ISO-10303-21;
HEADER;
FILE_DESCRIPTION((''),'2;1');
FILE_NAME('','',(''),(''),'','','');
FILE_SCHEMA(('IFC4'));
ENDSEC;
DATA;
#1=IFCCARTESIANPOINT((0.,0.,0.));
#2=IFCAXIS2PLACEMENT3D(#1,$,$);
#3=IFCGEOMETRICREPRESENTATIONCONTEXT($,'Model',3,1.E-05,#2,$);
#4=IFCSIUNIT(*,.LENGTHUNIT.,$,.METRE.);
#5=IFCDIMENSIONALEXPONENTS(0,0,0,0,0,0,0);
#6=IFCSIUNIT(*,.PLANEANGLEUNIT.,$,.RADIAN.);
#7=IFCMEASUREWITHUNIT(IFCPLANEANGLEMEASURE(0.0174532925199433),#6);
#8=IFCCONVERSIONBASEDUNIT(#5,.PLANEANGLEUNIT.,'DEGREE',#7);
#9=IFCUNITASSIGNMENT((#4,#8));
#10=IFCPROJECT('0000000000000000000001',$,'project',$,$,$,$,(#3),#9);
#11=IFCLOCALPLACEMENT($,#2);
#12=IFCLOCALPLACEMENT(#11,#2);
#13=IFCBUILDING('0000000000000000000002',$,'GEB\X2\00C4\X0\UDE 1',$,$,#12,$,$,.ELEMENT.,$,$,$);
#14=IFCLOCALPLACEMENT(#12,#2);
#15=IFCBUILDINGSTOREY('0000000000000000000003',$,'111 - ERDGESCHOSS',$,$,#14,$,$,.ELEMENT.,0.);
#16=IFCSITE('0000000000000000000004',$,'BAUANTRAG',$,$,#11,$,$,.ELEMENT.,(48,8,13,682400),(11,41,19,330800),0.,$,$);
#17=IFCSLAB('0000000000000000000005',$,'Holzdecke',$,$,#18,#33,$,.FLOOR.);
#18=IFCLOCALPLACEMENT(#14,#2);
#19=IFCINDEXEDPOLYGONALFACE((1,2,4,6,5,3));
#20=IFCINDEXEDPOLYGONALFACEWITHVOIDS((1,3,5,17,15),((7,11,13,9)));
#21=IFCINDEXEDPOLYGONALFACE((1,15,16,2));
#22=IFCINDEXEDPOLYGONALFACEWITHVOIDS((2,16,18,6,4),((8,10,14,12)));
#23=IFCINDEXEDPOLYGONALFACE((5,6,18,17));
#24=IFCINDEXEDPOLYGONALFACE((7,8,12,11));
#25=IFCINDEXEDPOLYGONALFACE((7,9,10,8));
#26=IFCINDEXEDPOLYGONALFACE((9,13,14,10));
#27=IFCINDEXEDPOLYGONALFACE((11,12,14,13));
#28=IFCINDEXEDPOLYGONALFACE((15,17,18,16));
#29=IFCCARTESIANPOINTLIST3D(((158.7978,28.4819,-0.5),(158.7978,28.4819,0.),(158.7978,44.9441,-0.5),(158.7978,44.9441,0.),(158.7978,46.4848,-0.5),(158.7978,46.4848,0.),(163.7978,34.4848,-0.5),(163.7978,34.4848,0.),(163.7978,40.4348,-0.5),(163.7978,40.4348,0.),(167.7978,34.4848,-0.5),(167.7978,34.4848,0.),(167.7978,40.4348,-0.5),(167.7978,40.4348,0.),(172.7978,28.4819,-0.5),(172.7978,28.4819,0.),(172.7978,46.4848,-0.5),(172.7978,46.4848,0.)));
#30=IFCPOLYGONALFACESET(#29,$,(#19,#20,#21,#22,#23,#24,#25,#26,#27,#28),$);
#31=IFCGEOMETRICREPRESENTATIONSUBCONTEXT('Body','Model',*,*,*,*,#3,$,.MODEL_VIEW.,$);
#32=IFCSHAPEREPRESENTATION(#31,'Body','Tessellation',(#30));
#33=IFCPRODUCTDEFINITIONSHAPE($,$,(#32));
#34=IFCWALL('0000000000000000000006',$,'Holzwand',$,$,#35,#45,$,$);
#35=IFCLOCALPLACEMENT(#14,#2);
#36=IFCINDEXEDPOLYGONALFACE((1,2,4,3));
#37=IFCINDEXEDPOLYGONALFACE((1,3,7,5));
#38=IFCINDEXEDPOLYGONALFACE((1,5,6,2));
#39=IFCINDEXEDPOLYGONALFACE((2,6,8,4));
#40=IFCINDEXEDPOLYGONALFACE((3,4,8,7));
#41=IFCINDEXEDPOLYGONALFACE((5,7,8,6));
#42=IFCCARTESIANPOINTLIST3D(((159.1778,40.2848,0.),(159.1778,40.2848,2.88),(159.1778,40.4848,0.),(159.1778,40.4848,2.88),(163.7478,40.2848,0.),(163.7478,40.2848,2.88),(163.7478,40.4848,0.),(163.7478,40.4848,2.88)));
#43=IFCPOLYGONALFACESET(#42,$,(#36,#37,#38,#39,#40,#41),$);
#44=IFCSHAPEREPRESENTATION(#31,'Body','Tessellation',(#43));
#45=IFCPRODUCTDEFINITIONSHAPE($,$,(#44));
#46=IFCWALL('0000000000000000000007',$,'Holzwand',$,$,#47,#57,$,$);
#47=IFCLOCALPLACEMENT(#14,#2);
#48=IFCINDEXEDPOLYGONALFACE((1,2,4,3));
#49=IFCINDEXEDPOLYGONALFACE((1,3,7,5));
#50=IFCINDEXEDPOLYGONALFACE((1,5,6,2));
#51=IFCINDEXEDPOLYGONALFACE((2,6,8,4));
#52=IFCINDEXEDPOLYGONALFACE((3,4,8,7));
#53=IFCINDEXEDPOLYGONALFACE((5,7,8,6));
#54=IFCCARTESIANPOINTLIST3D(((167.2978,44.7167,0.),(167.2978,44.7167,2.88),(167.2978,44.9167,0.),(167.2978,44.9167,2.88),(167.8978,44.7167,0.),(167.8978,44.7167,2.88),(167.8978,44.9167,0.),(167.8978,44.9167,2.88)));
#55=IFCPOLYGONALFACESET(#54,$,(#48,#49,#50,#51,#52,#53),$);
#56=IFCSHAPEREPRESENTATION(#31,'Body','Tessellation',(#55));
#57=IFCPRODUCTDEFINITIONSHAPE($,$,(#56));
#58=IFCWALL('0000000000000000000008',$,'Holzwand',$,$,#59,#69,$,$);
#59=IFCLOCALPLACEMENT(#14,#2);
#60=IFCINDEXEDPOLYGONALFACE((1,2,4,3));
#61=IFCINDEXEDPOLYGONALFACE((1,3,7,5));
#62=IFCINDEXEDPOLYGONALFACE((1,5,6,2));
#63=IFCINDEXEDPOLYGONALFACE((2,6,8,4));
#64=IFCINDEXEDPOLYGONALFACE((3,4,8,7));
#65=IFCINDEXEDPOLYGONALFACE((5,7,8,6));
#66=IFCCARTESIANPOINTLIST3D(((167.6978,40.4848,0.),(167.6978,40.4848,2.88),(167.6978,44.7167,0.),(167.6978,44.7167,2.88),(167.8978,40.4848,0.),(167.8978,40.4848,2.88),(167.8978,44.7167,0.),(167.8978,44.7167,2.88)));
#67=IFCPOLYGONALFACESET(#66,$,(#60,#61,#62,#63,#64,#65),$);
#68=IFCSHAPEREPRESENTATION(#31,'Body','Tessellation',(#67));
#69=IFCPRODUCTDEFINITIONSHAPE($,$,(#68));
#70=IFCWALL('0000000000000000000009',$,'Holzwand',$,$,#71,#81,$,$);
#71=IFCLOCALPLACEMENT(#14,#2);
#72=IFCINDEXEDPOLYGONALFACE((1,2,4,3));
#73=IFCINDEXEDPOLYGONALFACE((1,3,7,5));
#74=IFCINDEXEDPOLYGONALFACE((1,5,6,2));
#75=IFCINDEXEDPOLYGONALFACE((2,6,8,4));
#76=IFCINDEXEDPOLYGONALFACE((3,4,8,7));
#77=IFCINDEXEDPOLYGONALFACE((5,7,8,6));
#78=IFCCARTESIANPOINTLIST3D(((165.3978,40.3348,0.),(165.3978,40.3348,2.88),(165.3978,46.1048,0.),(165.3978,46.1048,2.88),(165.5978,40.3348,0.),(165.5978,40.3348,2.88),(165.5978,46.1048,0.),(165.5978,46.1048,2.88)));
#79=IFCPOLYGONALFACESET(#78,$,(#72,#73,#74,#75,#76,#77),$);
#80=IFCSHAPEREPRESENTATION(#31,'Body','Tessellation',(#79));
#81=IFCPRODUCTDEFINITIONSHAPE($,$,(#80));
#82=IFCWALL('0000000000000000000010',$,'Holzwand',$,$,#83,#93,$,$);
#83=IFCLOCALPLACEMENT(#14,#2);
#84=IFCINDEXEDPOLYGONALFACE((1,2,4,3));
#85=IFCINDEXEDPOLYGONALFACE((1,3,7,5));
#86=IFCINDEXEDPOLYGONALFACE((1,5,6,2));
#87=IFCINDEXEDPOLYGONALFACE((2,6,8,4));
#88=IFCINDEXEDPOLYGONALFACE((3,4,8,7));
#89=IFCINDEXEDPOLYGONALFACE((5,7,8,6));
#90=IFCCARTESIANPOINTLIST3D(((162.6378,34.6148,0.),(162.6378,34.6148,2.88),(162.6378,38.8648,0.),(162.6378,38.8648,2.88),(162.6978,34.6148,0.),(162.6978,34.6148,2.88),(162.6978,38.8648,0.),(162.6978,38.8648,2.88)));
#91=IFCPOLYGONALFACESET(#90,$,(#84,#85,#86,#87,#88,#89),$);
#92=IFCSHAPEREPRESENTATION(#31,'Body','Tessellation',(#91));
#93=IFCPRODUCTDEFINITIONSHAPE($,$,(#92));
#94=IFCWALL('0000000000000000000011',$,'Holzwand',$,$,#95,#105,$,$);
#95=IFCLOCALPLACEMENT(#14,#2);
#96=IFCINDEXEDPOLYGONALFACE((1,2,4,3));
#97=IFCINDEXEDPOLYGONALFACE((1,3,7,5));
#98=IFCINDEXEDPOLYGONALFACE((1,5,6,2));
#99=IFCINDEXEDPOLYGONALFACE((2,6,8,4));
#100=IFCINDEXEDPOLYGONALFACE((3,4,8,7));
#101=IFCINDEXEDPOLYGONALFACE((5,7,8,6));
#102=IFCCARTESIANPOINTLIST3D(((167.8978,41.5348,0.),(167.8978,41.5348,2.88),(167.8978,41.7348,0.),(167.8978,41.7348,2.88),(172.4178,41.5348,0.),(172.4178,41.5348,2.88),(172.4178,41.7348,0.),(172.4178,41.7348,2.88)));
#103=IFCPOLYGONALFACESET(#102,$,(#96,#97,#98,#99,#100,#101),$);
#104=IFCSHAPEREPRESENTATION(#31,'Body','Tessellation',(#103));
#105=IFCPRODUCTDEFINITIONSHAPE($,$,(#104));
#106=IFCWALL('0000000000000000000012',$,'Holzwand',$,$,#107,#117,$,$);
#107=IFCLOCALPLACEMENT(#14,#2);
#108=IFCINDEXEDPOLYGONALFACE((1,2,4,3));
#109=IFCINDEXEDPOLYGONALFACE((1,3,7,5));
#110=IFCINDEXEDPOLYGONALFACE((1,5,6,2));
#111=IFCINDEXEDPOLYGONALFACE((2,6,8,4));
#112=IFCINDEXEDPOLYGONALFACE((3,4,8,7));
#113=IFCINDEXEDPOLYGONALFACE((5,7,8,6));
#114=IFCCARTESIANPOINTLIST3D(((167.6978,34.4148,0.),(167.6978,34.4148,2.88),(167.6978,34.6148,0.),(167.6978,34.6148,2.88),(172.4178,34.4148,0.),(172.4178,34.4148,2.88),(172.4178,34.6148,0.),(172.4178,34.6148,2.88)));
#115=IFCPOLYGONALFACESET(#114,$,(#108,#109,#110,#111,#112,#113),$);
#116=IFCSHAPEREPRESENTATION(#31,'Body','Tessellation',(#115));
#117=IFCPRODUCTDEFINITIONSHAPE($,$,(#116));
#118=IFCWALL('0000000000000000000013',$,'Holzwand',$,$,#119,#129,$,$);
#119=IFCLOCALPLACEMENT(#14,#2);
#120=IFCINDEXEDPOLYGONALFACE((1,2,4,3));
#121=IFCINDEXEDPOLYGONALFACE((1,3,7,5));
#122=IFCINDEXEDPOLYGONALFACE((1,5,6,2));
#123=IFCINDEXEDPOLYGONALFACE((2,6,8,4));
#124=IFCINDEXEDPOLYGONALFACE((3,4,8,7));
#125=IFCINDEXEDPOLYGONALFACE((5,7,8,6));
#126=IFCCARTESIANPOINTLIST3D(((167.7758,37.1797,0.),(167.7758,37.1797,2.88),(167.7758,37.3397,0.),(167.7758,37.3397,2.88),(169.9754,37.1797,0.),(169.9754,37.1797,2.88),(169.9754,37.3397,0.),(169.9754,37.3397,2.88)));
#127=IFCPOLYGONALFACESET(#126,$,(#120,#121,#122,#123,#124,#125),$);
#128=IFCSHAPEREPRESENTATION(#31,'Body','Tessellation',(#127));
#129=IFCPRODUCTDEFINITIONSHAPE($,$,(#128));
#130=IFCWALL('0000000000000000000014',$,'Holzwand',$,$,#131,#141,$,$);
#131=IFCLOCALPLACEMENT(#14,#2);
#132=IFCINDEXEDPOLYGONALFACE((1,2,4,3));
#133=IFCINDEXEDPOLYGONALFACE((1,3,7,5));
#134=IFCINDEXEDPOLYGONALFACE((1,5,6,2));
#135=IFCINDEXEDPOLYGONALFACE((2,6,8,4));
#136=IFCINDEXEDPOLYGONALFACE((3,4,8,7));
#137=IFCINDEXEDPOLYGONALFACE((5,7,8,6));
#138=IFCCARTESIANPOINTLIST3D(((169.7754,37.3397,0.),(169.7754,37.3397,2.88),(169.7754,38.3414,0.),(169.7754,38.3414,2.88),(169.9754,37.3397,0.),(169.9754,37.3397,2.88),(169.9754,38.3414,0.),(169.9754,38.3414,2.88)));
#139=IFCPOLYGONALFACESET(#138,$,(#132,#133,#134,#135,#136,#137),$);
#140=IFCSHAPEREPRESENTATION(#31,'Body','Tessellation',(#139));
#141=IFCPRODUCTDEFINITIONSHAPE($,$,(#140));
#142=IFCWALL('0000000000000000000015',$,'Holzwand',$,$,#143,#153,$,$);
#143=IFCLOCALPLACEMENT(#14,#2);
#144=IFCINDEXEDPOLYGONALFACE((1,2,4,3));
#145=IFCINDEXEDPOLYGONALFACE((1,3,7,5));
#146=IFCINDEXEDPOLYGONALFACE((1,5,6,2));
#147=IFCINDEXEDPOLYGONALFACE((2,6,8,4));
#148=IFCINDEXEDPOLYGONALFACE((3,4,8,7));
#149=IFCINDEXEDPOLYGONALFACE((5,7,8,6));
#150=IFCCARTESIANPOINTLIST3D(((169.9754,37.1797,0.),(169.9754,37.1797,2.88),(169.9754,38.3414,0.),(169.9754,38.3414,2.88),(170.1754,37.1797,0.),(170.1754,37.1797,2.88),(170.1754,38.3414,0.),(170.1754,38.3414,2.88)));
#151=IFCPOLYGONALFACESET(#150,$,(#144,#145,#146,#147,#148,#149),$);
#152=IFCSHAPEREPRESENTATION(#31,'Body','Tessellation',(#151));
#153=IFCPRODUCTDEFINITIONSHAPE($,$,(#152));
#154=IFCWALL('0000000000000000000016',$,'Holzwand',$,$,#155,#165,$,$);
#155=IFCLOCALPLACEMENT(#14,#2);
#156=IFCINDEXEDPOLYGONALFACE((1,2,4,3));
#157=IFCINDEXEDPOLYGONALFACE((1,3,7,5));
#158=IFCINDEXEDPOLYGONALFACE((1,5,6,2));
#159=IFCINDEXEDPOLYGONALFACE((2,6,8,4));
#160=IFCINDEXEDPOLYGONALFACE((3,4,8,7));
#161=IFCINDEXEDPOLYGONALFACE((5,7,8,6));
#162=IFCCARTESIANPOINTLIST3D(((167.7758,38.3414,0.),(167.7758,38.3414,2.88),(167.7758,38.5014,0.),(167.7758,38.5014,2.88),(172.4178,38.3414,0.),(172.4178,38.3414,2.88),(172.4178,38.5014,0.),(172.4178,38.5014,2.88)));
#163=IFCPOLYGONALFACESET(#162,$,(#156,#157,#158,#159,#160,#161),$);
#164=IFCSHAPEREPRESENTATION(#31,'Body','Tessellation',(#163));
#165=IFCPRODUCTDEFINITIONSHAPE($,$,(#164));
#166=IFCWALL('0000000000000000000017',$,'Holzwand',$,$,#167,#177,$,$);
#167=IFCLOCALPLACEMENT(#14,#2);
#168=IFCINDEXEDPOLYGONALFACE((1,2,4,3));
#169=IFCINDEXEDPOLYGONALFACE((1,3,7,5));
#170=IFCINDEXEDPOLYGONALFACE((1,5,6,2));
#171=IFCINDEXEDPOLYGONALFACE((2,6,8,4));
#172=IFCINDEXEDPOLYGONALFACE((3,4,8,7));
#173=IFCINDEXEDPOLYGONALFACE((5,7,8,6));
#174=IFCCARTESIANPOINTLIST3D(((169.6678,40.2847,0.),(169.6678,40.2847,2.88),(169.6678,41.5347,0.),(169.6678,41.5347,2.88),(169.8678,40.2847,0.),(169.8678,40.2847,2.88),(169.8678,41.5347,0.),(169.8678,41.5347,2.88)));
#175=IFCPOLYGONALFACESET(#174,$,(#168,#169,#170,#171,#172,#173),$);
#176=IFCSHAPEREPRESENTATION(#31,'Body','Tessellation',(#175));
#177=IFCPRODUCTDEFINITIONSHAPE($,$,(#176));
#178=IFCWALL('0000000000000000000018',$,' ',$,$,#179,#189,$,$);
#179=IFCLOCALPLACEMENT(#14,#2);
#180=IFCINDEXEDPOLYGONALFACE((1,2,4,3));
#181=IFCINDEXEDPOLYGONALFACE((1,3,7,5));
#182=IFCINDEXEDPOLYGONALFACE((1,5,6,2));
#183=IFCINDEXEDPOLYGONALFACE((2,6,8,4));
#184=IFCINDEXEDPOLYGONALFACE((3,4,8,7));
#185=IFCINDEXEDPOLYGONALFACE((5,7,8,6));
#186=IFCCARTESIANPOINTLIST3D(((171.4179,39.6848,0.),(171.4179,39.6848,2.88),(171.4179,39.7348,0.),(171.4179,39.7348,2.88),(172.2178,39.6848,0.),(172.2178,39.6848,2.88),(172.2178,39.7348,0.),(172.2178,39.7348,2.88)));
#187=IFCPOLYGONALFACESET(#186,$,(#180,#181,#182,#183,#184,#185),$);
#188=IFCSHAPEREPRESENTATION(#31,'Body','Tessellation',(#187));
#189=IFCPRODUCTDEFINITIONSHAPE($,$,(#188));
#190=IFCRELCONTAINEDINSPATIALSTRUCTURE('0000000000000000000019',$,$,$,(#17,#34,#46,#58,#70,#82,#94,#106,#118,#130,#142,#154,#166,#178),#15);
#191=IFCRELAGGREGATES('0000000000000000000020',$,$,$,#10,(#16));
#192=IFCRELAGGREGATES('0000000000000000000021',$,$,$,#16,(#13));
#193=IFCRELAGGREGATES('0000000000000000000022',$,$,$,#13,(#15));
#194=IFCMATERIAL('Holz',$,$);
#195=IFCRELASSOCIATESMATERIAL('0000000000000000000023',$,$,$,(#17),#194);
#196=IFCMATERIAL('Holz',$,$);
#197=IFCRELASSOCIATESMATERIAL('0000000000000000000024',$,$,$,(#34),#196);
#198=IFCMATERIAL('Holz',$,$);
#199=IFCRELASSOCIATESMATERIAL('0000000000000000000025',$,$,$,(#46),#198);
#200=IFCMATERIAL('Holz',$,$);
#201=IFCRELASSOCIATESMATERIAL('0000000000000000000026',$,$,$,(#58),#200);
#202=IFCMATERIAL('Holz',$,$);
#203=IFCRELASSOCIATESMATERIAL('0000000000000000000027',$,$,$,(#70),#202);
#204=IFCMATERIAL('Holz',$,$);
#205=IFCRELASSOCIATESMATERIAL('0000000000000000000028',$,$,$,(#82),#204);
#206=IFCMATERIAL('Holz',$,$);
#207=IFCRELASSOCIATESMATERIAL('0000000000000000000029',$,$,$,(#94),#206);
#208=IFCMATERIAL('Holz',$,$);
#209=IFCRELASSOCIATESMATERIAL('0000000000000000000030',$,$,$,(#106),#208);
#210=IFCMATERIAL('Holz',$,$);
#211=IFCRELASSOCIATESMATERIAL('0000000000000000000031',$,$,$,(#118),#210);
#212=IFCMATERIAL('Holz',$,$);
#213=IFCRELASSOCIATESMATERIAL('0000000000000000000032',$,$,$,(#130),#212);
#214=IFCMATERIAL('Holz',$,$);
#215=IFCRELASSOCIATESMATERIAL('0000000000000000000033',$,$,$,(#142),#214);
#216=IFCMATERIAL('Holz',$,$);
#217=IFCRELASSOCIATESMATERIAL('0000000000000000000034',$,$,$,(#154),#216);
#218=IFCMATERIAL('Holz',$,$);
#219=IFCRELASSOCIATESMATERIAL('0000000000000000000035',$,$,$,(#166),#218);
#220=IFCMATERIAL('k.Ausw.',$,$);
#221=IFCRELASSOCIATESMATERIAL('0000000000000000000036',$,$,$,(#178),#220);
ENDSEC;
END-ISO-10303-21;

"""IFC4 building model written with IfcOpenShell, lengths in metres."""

from ifc_helpers import new_model, entity, si_unit, converted_unit, frame, origin, origin_with_axes, place, context, subcontext, project, spatial, indexed_curve, outline, extrude, material, element, save


model = new_model("IFC4")

# Units and contexts
model_context = context("Model", 3, precision=1e-05, world=origin())
body_context = subcontext(model_context, "Body", "Model", "MODEL_VIEW")
ifc_project = project(units=[si_unit("LENGTHUNIT", "METRE"), converted_unit("PLANEANGLEUNIT", "DEGREE", entity("IfcPlaneAngleMeasure", 0.0174532925199433), si_unit("PLANEANGLEUNIT", "RADIAN"), dimensions=[0, 0, 0, 0, 0, 0, 0])], contexts=[model_context])

# Site, building, storey
site_placement = place(None, origin())
site = spatial("IfcSite", under=ifc_project, at=site_placement, Name="BAUANTRAG", CompositionType="ELEMENT", RefLatitude=(48, 8, 13, 682400), RefLongitude=(11, 41, 19, 330800), RefElevation=0.0)
building_placement = place(site_placement, origin())
building = spatial("IfcBuilding", under=site, at=building_placement, Name="GEBÄUDE 1", CompositionType="ELEMENT")
storey_placement = place(building_placement, origin())
storey = spatial("IfcBuildingStorey", under=building, at=storey_placement, Name="111 - ERDGESCHOSS", CompositionType="ELEMENT", Elevation=0.0)

# Slab
ifc_material_1 = material(Name="Holz")
slab_placement = place(storey_placement, frame((158.7978, 28.4819, -0.5)))
element("IfcSlab", 1, at=slab_placement, inside=storey, material=ifc_material_1, Name="Holzdecke", PredefinedType="FLOOR", context=body_context, shape_type="SweptSolid", body=[
    extrude(outline(indexed_curve([(0.0, 16.4622), (0.0, 0.0), (14.0, 0.0), (14.0, 18.0029), (0.0, 18.0029), (0.0, 16.4622)], self_intersect=False), holes=[indexed_curve([(5.0, 11.9529), (9.0, 11.9529), (9.0, 6.0029), (5.0, 6.0029), (5.0, 11.9529)], self_intersect=False)]), origin_with_axes(), (0.0, 0.0, 1.0), 0.5),
])

# Walls
ifc_material_2 = material(Name="Holz")
wall_1_placement = place(storey_placement, frame((163.7478, 40.4848, 0.0), z_axis=(0.0, 0.0, 1.0), x_axis=(-1.0, 0.0, 0.0)))
element("IfcWall", 2, at=wall_1_placement, inside=storey, material=ifc_material_2, Name="Holzwand", context=body_context, shape_type="SweptSolid", body=[
    extrude(outline(indexed_curve([(-4.57, -0.2), (0.0, -0.2), (0.0, 0.0), (-4.57, 0.0), (-4.57, -0.2)], self_intersect=False)), frame((4.57, 0.2, 0.0), z_axis=(0.0, 0.0, 1.0), x_axis=(1.0, 0.0, 0.0)), (0.0, 0.0, 1.0), 2.88),
])
ifc_material_3 = material(Name="Holz")
wall_2_placement = place(storey_placement, frame((167.2978, 44.7167, 0.0)))
element("IfcWall", 3, at=wall_2_placement, inside=storey, material=ifc_material_3, Name="Holzwand", context=body_context, shape_type="SweptSolid", body=[
    extrude(outline(indexed_curve([(0.0, 0.0), (0.6, 0.0), (0.6, 0.2), (0.0, 0.2), (0.0, 0.0)], self_intersect=False)), origin_with_axes(), (0.0, 0.0, 1.0), 2.88),
])
ifc_material_4 = material(Name="Holz")
wall_3_placement = place(storey_placement, frame((167.6978, 44.7167, 0.0), z_axis=(0.0, 0.0, 1.0), x_axis=(0.0, -1.0, 0.0)))
element("IfcWall", 4, at=wall_3_placement, inside=storey, material=ifc_material_4, Name="Holzwand", context=body_context, shape_type="SweptSolid", body=[
    extrude(outline(indexed_curve([(-4.2319, 0.0), (0.0, 0.0), (0.0, 0.2), (-4.2319, 0.2), (-4.2319, 0.0)], self_intersect=False)), frame((4.2319, 0.0, 0.0), z_axis=(0.0, 0.0, 1.0), x_axis=(1.0, 0.0, 0.0)), (0.0, 0.0, 1.0), 2.88),
])
ifc_material_5 = material(Name="Holz")
wall_4_placement = place(storey_placement, frame((165.3978, 46.1048, 0.0), z_axis=(0.0, 0.0, 1.0), x_axis=(0.0, -1.0, 0.0)))
element("IfcWall", 5, at=wall_4_placement, inside=storey, material=ifc_material_5, Name="Holzwand", context=body_context, shape_type="SweptSolid", body=[
    extrude(outline(indexed_curve([(-5.77, 0.0), (0.0, 0.0), (0.0, 0.2), (-5.77, 0.2), (-5.77, 0.0)], self_intersect=False)), frame((5.77, 0.0, 0.0), z_axis=(0.0, 0.0, 1.0), x_axis=(1.0, 0.0, 0.0)), (0.0, 0.0, 1.0), 2.88),
])
ifc_material_6 = material(Name="Holz")
wall_5_placement = place(storey_placement, frame((162.6978, 34.6148, 0.0), z_axis=(0.0, 0.0, 1.0), x_axis=(0.0, 1.0, 0.0)))
element("IfcWall", 6, at=wall_5_placement, inside=storey, material=ifc_material_6, Name="Holzwand", context=body_context, shape_type="SweptSolid", body=[
    extrude(outline(indexed_curve([(0.0, -0.06), (4.25, -0.06), (4.25, 0.0), (0.0, 0.0), (0.0, -0.06)], self_intersect=False)), frame((0.0, 0.06, 0.0), z_axis=(0.0, 0.0, 1.0), x_axis=(1.0, 0.0, 0.0)), (0.0, 0.0, 1.0), 2.88),
])
ifc_material_7 = material(Name="Holz")
wall_6_placement = place(storey_placement, frame((172.4178, 41.7348, 0.0), z_axis=(0.0, 0.0, 1.0), x_axis=(-1.0, 0.0, 0.0)))
element("IfcWall", 7, at=wall_6_placement, inside=storey, material=ifc_material_7, Name="Holzwand", context=body_context, shape_type="SweptSolid", body=[
    extrude(outline(indexed_curve([(-4.52, -0.2), (0.0, -0.2), (0.0, 0.0), (-4.52, 0.0), (-4.52, -0.2)], self_intersect=False)), frame((4.52, 0.2, 0.0), z_axis=(0.0, 0.0, 1.0), x_axis=(1.0, 0.0, 0.0)), (0.0, 0.0, 1.0), 2.88),
])
ifc_material_8 = material(Name="Holz")
wall_7_placement = place(storey_placement, frame((167.6978, 34.4148, 0.0)))
element("IfcWall", 8, at=wall_7_placement, inside=storey, material=ifc_material_8, Name="Holzwand", context=body_context, shape_type="SweptSolid", body=[
    extrude(outline(indexed_curve([(0.0, 0.0), (4.72, 0.0), (4.72, 0.2), (0.0, 0.2), (0.0, 0.0)], self_intersect=False)), origin_with_axes(), (0.0, 0.0, 1.0), 2.88),
])
ifc_material_9 = material(Name="Holz")
wall_8_placement = place(storey_placement, frame((169.9754, 37.3397, 0.0), z_axis=(0.0, 0.0, 1.0), x_axis=(-1.0, 0.0, 0.0)))
element("IfcWall", 9, at=wall_8_placement, inside=storey, material=ifc_material_9, Name="Holzwand", context=body_context, shape_type="SweptSolid", body=[
    extrude(outline(indexed_curve([(-2.1997, -0.16), (0.0, -0.16), (0.0, 0.0), (-2.1997, 0.0), (-2.1997, -0.16)], self_intersect=False)), frame((2.1997, 0.16, 0.0), z_axis=(0.0, 0.0, 1.0), x_axis=(1.0, 0.0, 0.0)), (0.0, 0.0, 1.0), 2.88),
])
ifc_material_10 = material(Name="Holz")
wall_9_placement = place(storey_placement, frame((169.9754, 37.3397, 0.0), z_axis=(0.0, 0.0, 1.0), x_axis=(0.0, 1.0, 0.0)))
element("IfcWall", 10, at=wall_9_placement, inside=storey, material=ifc_material_10, Name="Holzwand", context=body_context, shape_type="SweptSolid", body=[
    extrude(outline(indexed_curve([(0.0, -0.2), (1.0017, -0.2), (1.0017, 0.0), (0.0, 0.0), (0.0, -0.2)], self_intersect=False)), frame((0.0, 0.2, 0.0), z_axis=(0.0, 0.0, 1.0), x_axis=(1.0, 0.0, 0.0)), (0.0, 0.0, 1.0), 2.88),
])
ifc_material_11 = material(Name="Holz")
wall_10_placement = place(storey_placement, frame((170.1754, 37.1797, 0.0), z_axis=(0.0, 0.0, 1.0), x_axis=(0.0, 1.0, 0.0)))
element("IfcWall", 11, at=wall_10_placement, inside=storey, material=ifc_material_11, Name="Holzwand", context=body_context, shape_type="SweptSolid", body=[
    extrude(outline(indexed_curve([(0.0, -0.2), (1.1617, -0.2), (1.1617, 0.0), (0.0, 0.0), (0.0, -0.2)], self_intersect=False)), frame((0.0, 0.2, 0.0), z_axis=(0.0, 0.0, 1.0), x_axis=(1.0, 0.0, 0.0)), (0.0, 0.0, 1.0), 2.88),
])
ifc_material_12 = material(Name="Holz")
wall_11_placement = place(storey_placement, frame((172.4178, 38.5014, 0.0), z_axis=(0.0, 0.0, 1.0), x_axis=(-1.0, 0.0, 0.0)))
element("IfcWall", 12, at=wall_11_placement, inside=storey, material=ifc_material_12, Name="Holzwand", context=body_context, shape_type="SweptSolid", body=[
    extrude(outline(indexed_curve([(-4.642, -0.16), (0.0, -0.16), (0.0, 0.0), (-4.642, 0.0), (-4.642, -0.16)], self_intersect=False)), frame((4.642, 0.16, 0.0), z_axis=(0.0, 0.0, 1.0), x_axis=(1.0, 0.0, 0.0)), (0.0, 0.0, 1.0), 2.88),
])
ifc_material_13 = material(Name="Holz")
wall_12_placement = place(storey_placement, frame((169.8678, 40.2847, 0.0), z_axis=(0.0, 0.0, 1.0), x_axis=(0.0, 1.0, 0.0)))
element("IfcWall", 13, at=wall_12_placement, inside=storey, material=ifc_material_13, Name="Holzwand", context=body_context, shape_type="SweptSolid", body=[
    extrude(outline(indexed_curve([(0.0, -0.2), (1.25, -0.2), (1.25, 0.0), (0.0, 0.0), (0.0, -0.2)], self_intersect=False)), frame((0.0, 0.2, 0.0), z_axis=(0.0, 0.0, 1.0), x_axis=(1.0, 0.0, 0.0)), (0.0, 0.0, 1.0), 2.88),
])
ifc_material_14 = material(Name="k.Ausw.")
wall_13_placement = place(storey_placement, frame((172.2178, 39.7348, 0.0), z_axis=(0.0, 0.0, 1.0), x_axis=(-1.0, 0.0, 0.0)))
element("IfcWall", 14, at=wall_13_placement, inside=storey, material=ifc_material_14, Name=" ", context=body_context, shape_type="SweptSolid", body=[
    extrude(outline(indexed_curve([(-0.7998, -0.05), (0.0, -0.05), (0.0, 0.0), (-0.7998, 0.0), (-0.7998, -0.05)], self_intersect=False)), frame((0.7998, 0.05, 0.0), z_axis=(0.0, 0.0, 1.0), x_axis=(1.0, 0.0, 0.0)), (0.0, 0.0, 1.0), 2.88),
])

save(model, "model.ifc")
